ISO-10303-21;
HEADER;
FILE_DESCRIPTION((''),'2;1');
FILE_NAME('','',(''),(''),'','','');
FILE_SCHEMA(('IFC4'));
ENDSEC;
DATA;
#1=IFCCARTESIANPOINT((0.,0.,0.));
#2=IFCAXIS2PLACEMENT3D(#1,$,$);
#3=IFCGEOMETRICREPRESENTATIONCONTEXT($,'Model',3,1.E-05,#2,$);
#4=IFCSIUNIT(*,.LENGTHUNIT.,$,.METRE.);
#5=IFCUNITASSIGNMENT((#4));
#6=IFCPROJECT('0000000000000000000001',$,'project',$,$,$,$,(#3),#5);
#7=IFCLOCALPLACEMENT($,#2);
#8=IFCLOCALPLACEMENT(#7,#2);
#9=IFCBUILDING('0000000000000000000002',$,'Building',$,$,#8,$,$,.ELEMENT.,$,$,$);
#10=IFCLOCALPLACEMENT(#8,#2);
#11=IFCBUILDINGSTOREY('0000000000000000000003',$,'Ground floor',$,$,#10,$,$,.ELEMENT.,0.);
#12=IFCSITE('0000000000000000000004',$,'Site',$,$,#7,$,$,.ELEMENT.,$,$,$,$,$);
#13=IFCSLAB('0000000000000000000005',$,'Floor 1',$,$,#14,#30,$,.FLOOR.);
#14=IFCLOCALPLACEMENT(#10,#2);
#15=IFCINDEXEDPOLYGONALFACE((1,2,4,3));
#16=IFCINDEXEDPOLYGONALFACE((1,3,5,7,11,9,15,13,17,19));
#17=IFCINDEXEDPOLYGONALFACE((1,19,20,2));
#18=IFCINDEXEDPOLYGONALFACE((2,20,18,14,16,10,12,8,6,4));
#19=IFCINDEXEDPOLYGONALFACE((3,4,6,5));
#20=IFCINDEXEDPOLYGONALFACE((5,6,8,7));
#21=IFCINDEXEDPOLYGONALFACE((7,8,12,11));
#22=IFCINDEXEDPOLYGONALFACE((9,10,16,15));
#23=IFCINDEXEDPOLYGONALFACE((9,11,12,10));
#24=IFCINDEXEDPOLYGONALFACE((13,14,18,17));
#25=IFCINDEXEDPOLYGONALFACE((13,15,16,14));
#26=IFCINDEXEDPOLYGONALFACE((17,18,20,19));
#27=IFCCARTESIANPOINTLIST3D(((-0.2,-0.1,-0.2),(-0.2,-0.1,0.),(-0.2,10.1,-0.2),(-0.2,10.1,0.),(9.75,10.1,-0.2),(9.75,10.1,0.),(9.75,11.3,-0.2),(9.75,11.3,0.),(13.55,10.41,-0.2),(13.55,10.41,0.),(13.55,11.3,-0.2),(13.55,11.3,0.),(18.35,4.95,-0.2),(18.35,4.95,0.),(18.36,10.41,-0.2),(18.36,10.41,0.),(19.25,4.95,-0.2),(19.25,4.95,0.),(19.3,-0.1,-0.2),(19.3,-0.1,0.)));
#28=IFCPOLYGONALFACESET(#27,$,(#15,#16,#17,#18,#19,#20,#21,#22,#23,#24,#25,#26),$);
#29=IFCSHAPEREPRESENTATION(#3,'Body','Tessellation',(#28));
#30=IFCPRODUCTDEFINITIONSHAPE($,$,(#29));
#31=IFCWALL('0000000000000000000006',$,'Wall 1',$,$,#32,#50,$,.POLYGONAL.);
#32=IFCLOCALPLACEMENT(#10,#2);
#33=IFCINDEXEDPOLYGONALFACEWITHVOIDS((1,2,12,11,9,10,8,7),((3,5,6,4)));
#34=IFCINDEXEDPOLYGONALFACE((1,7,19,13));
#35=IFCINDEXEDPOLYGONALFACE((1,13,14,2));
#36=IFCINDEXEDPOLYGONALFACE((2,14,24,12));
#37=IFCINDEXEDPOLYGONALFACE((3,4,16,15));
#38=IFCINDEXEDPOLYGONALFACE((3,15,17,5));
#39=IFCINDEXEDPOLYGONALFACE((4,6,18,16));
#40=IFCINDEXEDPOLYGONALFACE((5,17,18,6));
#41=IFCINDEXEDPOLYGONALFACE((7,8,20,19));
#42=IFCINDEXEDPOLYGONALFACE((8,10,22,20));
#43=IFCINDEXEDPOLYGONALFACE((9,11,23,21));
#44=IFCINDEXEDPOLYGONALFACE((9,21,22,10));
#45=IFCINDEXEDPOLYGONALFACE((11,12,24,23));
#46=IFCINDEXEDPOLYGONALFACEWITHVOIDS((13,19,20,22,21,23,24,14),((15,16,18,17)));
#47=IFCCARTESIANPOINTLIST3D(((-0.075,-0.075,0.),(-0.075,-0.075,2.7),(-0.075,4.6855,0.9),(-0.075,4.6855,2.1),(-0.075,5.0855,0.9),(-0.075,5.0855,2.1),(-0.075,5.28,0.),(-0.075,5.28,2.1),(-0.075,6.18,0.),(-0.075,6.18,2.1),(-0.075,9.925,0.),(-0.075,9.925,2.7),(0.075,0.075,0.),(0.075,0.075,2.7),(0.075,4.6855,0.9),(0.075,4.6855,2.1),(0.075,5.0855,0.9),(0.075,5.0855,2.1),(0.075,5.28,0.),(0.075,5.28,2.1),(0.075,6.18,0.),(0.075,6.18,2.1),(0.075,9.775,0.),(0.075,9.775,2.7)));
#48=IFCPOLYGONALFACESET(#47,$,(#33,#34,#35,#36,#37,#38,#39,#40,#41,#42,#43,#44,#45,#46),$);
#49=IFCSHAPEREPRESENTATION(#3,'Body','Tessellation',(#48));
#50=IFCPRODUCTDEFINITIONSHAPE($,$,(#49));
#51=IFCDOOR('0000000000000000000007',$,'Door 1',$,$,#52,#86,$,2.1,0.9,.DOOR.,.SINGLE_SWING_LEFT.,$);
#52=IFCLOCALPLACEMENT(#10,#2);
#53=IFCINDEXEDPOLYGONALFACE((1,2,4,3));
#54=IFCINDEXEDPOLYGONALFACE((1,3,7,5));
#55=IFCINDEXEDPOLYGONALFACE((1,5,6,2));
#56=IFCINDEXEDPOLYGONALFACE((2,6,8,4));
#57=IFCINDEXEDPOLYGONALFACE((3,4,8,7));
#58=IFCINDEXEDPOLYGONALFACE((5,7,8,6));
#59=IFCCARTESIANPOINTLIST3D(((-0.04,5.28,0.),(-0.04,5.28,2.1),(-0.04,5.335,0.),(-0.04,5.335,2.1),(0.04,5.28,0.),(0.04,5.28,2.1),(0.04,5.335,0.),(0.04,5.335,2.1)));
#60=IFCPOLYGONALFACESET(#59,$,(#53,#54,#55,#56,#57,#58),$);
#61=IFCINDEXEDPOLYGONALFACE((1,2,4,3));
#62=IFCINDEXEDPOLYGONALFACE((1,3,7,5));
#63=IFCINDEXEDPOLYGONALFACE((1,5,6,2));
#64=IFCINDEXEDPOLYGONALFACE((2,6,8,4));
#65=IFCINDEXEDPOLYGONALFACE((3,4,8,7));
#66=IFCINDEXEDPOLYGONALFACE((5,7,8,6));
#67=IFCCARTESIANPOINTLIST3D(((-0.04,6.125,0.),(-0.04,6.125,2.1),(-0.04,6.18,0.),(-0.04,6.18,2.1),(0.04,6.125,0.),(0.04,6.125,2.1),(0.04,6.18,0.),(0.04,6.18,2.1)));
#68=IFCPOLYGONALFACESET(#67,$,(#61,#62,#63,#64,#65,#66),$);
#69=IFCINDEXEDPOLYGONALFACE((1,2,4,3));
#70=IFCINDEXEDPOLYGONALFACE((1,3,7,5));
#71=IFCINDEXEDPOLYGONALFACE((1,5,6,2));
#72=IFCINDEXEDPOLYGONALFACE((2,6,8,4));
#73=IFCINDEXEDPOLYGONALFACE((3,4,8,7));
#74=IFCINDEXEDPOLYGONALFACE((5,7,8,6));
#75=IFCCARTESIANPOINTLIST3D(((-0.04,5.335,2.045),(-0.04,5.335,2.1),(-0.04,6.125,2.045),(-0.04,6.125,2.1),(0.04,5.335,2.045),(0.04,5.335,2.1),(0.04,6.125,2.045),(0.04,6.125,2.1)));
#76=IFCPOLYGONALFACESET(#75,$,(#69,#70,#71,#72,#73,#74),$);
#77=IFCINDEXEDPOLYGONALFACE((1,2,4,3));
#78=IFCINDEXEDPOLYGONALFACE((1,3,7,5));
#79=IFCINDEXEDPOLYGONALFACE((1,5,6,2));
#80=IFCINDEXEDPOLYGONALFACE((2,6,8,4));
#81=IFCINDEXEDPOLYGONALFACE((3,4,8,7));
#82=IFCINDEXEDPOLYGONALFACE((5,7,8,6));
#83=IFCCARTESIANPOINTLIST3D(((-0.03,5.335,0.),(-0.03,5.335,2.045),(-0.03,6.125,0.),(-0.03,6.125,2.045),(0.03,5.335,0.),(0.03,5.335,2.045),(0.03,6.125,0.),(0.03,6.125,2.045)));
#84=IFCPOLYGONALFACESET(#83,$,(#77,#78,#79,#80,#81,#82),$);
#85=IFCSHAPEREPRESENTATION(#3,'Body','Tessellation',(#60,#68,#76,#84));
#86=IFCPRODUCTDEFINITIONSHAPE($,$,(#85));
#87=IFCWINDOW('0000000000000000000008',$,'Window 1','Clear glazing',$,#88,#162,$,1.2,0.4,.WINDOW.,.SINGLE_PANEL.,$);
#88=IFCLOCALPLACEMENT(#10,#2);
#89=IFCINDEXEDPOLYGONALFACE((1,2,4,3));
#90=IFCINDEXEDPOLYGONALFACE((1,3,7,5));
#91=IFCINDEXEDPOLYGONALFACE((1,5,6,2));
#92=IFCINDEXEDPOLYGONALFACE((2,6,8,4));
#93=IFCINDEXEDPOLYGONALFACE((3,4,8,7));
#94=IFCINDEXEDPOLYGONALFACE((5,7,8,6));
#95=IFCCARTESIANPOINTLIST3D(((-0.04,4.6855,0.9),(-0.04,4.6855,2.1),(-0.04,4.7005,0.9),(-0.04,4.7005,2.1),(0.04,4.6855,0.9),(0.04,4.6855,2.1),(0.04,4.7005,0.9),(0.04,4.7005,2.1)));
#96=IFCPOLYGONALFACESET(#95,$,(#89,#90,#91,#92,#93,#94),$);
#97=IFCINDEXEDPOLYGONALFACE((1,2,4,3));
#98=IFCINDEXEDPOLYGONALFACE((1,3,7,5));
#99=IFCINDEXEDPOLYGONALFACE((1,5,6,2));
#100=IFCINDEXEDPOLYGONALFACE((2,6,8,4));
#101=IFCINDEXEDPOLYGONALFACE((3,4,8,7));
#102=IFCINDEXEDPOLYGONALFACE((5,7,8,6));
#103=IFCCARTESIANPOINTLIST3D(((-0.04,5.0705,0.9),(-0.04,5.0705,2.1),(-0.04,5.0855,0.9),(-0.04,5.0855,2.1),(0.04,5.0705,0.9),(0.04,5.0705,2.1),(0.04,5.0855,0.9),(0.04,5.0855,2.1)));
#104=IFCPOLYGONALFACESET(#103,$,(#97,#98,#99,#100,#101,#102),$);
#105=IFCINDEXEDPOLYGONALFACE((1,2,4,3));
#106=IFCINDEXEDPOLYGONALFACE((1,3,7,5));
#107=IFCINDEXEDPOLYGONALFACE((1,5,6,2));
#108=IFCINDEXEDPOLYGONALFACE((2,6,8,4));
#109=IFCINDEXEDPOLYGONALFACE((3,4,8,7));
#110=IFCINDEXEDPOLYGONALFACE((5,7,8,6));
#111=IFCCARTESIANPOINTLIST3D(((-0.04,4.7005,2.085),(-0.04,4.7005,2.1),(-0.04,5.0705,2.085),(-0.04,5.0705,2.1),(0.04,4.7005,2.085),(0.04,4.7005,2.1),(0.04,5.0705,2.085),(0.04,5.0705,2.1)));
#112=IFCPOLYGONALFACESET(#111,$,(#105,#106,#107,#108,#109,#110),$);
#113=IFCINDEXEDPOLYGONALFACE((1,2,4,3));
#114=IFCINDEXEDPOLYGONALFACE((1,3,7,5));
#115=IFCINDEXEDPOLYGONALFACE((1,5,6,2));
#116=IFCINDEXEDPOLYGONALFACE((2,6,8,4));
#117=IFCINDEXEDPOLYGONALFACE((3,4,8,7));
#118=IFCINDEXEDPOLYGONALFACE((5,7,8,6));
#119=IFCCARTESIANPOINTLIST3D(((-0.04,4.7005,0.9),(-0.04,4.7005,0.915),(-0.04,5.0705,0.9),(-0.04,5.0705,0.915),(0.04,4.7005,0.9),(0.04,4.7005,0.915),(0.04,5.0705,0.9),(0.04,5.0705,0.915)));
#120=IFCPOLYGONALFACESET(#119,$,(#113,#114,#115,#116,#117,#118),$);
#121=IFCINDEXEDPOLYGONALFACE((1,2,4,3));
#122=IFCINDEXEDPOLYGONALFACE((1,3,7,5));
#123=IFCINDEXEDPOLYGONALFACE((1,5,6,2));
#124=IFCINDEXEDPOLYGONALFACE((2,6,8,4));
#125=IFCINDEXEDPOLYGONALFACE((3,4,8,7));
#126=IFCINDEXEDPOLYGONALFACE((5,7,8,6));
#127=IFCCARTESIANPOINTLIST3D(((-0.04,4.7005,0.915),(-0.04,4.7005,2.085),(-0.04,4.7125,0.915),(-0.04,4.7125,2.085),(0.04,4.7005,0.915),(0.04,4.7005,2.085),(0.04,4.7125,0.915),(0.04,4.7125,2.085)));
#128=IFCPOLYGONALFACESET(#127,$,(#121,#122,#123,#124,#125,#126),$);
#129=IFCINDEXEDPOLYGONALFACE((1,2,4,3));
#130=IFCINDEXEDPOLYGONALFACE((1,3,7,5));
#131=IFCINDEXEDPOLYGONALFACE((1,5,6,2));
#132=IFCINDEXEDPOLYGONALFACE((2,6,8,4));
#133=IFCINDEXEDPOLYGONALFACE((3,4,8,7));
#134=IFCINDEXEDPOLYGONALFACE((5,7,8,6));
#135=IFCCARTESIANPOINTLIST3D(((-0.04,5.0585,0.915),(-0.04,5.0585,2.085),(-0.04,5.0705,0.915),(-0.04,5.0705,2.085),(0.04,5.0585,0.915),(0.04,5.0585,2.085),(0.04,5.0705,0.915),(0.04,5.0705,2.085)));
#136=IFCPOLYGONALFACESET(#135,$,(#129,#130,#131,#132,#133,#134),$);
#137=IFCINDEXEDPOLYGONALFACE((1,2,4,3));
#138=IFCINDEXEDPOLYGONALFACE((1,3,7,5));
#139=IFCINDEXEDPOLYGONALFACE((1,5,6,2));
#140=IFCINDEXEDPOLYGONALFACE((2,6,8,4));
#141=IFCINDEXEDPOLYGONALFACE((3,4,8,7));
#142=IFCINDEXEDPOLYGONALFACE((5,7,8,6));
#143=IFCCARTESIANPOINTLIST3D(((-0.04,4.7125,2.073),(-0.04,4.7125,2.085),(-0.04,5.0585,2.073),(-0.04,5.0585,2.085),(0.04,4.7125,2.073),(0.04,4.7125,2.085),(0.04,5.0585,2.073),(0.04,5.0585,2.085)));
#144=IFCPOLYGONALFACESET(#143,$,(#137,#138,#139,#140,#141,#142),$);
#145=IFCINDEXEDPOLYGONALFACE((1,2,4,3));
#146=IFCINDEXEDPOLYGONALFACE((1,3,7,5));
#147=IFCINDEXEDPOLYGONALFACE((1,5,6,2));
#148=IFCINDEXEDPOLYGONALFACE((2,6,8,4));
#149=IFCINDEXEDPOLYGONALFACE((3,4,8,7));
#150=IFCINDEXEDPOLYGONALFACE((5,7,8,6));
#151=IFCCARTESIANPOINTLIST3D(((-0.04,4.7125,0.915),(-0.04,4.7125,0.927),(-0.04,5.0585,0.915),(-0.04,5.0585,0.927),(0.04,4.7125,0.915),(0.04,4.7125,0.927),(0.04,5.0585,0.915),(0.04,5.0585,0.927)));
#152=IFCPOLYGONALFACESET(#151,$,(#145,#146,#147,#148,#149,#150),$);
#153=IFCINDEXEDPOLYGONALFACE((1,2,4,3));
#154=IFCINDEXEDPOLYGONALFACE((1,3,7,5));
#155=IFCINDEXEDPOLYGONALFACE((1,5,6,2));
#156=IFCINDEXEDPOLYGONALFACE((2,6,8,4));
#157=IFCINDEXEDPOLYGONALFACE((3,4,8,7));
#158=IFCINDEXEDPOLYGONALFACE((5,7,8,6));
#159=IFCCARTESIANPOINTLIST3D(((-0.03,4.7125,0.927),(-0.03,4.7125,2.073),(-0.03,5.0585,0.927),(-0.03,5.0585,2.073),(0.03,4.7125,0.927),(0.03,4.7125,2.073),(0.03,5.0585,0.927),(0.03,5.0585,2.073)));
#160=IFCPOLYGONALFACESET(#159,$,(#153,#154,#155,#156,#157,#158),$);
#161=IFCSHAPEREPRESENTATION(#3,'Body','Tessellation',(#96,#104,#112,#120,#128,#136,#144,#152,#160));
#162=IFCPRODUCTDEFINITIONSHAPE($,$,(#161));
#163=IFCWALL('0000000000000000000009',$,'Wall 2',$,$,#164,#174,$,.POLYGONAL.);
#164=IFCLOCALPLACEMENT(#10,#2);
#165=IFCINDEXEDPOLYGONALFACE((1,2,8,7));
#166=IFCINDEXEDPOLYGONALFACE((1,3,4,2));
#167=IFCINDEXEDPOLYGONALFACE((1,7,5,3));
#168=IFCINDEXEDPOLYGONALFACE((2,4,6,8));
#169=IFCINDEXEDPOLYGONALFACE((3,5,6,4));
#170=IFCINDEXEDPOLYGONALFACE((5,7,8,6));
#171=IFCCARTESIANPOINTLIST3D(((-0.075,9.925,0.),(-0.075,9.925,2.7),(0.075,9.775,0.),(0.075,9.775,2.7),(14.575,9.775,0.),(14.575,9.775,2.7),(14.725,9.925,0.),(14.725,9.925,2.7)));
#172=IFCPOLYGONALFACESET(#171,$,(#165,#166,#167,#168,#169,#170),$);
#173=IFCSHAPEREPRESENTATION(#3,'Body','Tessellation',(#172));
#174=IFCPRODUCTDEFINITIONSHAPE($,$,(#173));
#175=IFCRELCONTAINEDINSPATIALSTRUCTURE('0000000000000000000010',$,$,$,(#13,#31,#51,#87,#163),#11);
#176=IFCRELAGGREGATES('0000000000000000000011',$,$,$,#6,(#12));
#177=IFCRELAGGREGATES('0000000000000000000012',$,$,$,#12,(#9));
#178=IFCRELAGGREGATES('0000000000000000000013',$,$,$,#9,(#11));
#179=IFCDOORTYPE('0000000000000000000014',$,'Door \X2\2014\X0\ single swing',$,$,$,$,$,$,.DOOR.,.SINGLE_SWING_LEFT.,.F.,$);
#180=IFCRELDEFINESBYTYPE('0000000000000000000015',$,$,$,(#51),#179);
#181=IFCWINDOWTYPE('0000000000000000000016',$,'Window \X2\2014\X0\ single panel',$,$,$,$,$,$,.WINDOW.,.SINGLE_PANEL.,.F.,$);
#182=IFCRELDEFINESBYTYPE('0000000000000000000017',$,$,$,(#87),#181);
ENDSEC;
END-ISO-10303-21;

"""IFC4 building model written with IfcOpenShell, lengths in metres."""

from ifc_helpers import new_model, si_unit, frame, frame_2d, origin, origin_with_axes, place, context, project, spatial, polyline, rectangle, outline, extrude, type_object, element, fill, save


model = new_model("IFC4")

# Units and contexts
model_context = context("Model", 3, precision=1e-05, world=origin())
ifc_project = project(units=[si_unit("LENGTHUNIT", "METRE")], contexts=[model_context])

# Site, building, storey
site_placement = place(None, origin())
site = spatial("IfcSite", under=ifc_project, at=site_placement, Name="Site", CompositionType="ELEMENT")
building_placement = place(site_placement, origin())
building = spatial("IfcBuilding", under=site, at=building_placement, Name="Building", CompositionType="ELEMENT")
storey_placement = place(building_placement, origin())
storey = spatial("IfcBuildingStorey", under=building, at=storey_placement, Name="Ground floor", CompositionType="ELEMENT", Elevation=0.0)

# Slab
slab_placement = place(storey_placement, frame((0.0, 0.0, -0.2), z_axis=(0.0, 0.0, 1.0), x_axis=(1.0, 0.0, 0.0)))
element("IfcSlab", 1, at=slab_placement, inside=storey, Name="Floor 1", PredefinedType="FLOOR", context=model_context, shape_type="SweptSolid", body=[
    extrude(outline(polyline([(-0.2, -0.1), (-0.2, 10.1), (9.75, 10.1), (9.75, 11.3), (13.55, 11.3), (13.55, 10.41), (18.36, 10.41), (18.35, 4.95), (19.25, 4.95), (19.3, -0.1), (-0.2, -0.1)])), origin(), (0.0, 0.0, 1.0), 0.2),
])

# Wall, openings, door, window
wall_1_placement = place(storey_placement, origin_with_axes())
wall_1 = element("IfcWall", 2, at=wall_1_placement, inside=storey, Name="Wall 1", PredefinedType="POLYGONAL", context=model_context, shape_type="SweptSolid", body=[
    extrude(outline(polyline([(-0.075, -0.075), (0.075, 0.075), (0.075, 9.775), (-0.075, 9.925), (-0.075, -0.075)])), origin(), (0.0, 0.0, 1.0), 2.7),
])
opening_1_placement = place(storey_placement, frame((0.0, 5.28, 0.0), z_axis=(0.0, 0.0, 1.0), x_axis=(0.0, 1.0, 0.0)))
opening_1 = element("IfcOpeningElement", 3, at=opening_1_placement, cuts=wall_1, PredefinedType="OPENING", context=model_context, shape_type="SweptSolid", body=[
    extrude(rectangle(XDim=0.9, YDim=0.21, at=frame_2d((0.45, 0.0))), origin(), (0.0, 0.0, 1.0), 2.1),
])
opening_2_placement = place(storey_placement, frame((0.0, 4.6855, 0.9), z_axis=(0.0, 0.0, 1.0), x_axis=(0.0, 1.0, 0.0)))
opening_2 = element("IfcOpeningElement", 4, at=opening_2_placement, cuts=wall_1, PredefinedType="OPENING", context=model_context, shape_type="SweptSolid", body=[
    extrude(rectangle(XDim=0.4, YDim=0.21, at=frame_2d((0.2, 0.0))), origin(), (0.0, 0.0, 1.0), 1.2),
])
door_type_1 = type_object("IfcDoorType", Name="Door — single swing", OperationType="SINGLE_SWING_LEFT", ParameterTakesPrecedence=False, PredefinedType="DOOR")
door_1_placement = place(storey_placement, frame((0.0, 5.28, 0.0), z_axis=(0.0, 0.0, 1.0), x_axis=(0.0, 1.0, 0.0)))
door_1 = element("IfcDoor", 5, at=door_1_placement, inside=storey, type_object=door_type_1, Name="Door 1", OperationType="SINGLE_SWING_LEFT", OverallHeight=2.1, OverallWidth=0.9, PredefinedType="DOOR", context=model_context, shape_type="SweptSolid", body=[
    extrude(rectangle(XDim=0.055, YDim=0.08, at=frame_2d((0.0275, 0.0))), origin(), (0.0, 0.0, 1.0), 2.1),
    extrude(rectangle(XDim=0.055, YDim=0.08, at=frame_2d((0.8725, 0.0))), origin(), (0.0, 0.0, 1.0), 2.1),
    extrude(rectangle(XDim=0.79, YDim=0.08, at=frame_2d((0.45, 0.0))), frame((0.0, 0.0, 2.045)), (0.0, 0.0, 1.0), 0.055),
    extrude(rectangle(XDim=0.79, YDim=0.06, at=frame_2d((0.45, 0.0))), origin(), (0.0, 0.0, 1.0), 2.045),
])
fill(opening_1, door_1)
window_type = type_object("IfcWindowType", Name="Window — single panel", ParameterTakesPrecedence=False, PartitioningType="SINGLE_PANEL", PredefinedType="WINDOW")
window_placement = place(storey_placement, frame((0.0, 4.6855, 0.9), z_axis=(0.0, 0.0, 1.0), x_axis=(0.0, 1.0, 0.0)))
window = element("IfcWindow", 6, at=window_placement, inside=storey, type_object=window_type, Name="Window 1", Description="Clear glazing", OverallHeight=1.2, OverallWidth=0.4, PartitioningType="SINGLE_PANEL", PredefinedType="WINDOW", context=model_context, shape_type="SweptSolid", body=[
    extrude(rectangle(XDim=0.015, YDim=0.08, at=frame_2d((0.0075, 0.0))), origin(), (0.0, 0.0, 1.0), 1.2),
    extrude(rectangle(XDim=0.015, YDim=0.08, at=frame_2d((0.3925, 0.0))), origin(), (0.0, 0.0, 1.0), 1.2),
    extrude(rectangle(XDim=0.37, YDim=0.08, at=frame_2d((0.2, 0.0))), frame((0.0, 0.0, 1.185)), (0.0, 0.0, 1.0), 0.015),
    extrude(rectangle(XDim=0.37, YDim=0.08, at=frame_2d((0.2, 0.0))), origin(), (0.0, 0.0, 1.0), 0.015),
    extrude(rectangle(XDim=0.012, YDim=0.08, at=frame_2d((0.021, 0.0))), frame((0.0, 0.0, 0.015)), (0.0, 0.0, 1.0), 1.17),
    extrude(rectangle(XDim=0.012, YDim=0.08, at=frame_2d((0.379, 0.0))), frame((0.0, 0.0, 0.015)), (0.0, 0.0, 1.0), 1.17),
    extrude(rectangle(XDim=0.346, YDim=0.08, at=frame_2d((0.2, 0.0))), frame((0.0, 0.0, 1.173)), (0.0, 0.0, 1.0), 0.012),
    extrude(rectangle(XDim=0.346, YDim=0.08, at=frame_2d((0.2, 0.0))), frame((0.0, 0.0, 0.015)), (0.0, 0.0, 1.0), 0.012),
    extrude(rectangle(XDim=0.346, YDim=0.06, at=frame_2d((0.2, 0.0))), frame((0.0, 0.0, 0.027)), (0.0, 0.0, 1.0), 1.146),
])
fill(opening_2, window)

# Wall
wall_2_placement = place(storey_placement, origin_with_axes())
element("IfcWall", 7, at=wall_2_placement, inside=storey, Name="Wall 2", PredefinedType="POLYGONAL", context=model_context, shape_type="SweptSolid", body=[
    extrude(outline(polyline([(-0.075, 9.925), (0.075, 9.775), (14.575, 9.775), (14.725, 9.925), (-0.075, 9.925)])), origin(), (0.0, 0.0, 1.0), 2.7),
])

save(model, "model.ifc")
